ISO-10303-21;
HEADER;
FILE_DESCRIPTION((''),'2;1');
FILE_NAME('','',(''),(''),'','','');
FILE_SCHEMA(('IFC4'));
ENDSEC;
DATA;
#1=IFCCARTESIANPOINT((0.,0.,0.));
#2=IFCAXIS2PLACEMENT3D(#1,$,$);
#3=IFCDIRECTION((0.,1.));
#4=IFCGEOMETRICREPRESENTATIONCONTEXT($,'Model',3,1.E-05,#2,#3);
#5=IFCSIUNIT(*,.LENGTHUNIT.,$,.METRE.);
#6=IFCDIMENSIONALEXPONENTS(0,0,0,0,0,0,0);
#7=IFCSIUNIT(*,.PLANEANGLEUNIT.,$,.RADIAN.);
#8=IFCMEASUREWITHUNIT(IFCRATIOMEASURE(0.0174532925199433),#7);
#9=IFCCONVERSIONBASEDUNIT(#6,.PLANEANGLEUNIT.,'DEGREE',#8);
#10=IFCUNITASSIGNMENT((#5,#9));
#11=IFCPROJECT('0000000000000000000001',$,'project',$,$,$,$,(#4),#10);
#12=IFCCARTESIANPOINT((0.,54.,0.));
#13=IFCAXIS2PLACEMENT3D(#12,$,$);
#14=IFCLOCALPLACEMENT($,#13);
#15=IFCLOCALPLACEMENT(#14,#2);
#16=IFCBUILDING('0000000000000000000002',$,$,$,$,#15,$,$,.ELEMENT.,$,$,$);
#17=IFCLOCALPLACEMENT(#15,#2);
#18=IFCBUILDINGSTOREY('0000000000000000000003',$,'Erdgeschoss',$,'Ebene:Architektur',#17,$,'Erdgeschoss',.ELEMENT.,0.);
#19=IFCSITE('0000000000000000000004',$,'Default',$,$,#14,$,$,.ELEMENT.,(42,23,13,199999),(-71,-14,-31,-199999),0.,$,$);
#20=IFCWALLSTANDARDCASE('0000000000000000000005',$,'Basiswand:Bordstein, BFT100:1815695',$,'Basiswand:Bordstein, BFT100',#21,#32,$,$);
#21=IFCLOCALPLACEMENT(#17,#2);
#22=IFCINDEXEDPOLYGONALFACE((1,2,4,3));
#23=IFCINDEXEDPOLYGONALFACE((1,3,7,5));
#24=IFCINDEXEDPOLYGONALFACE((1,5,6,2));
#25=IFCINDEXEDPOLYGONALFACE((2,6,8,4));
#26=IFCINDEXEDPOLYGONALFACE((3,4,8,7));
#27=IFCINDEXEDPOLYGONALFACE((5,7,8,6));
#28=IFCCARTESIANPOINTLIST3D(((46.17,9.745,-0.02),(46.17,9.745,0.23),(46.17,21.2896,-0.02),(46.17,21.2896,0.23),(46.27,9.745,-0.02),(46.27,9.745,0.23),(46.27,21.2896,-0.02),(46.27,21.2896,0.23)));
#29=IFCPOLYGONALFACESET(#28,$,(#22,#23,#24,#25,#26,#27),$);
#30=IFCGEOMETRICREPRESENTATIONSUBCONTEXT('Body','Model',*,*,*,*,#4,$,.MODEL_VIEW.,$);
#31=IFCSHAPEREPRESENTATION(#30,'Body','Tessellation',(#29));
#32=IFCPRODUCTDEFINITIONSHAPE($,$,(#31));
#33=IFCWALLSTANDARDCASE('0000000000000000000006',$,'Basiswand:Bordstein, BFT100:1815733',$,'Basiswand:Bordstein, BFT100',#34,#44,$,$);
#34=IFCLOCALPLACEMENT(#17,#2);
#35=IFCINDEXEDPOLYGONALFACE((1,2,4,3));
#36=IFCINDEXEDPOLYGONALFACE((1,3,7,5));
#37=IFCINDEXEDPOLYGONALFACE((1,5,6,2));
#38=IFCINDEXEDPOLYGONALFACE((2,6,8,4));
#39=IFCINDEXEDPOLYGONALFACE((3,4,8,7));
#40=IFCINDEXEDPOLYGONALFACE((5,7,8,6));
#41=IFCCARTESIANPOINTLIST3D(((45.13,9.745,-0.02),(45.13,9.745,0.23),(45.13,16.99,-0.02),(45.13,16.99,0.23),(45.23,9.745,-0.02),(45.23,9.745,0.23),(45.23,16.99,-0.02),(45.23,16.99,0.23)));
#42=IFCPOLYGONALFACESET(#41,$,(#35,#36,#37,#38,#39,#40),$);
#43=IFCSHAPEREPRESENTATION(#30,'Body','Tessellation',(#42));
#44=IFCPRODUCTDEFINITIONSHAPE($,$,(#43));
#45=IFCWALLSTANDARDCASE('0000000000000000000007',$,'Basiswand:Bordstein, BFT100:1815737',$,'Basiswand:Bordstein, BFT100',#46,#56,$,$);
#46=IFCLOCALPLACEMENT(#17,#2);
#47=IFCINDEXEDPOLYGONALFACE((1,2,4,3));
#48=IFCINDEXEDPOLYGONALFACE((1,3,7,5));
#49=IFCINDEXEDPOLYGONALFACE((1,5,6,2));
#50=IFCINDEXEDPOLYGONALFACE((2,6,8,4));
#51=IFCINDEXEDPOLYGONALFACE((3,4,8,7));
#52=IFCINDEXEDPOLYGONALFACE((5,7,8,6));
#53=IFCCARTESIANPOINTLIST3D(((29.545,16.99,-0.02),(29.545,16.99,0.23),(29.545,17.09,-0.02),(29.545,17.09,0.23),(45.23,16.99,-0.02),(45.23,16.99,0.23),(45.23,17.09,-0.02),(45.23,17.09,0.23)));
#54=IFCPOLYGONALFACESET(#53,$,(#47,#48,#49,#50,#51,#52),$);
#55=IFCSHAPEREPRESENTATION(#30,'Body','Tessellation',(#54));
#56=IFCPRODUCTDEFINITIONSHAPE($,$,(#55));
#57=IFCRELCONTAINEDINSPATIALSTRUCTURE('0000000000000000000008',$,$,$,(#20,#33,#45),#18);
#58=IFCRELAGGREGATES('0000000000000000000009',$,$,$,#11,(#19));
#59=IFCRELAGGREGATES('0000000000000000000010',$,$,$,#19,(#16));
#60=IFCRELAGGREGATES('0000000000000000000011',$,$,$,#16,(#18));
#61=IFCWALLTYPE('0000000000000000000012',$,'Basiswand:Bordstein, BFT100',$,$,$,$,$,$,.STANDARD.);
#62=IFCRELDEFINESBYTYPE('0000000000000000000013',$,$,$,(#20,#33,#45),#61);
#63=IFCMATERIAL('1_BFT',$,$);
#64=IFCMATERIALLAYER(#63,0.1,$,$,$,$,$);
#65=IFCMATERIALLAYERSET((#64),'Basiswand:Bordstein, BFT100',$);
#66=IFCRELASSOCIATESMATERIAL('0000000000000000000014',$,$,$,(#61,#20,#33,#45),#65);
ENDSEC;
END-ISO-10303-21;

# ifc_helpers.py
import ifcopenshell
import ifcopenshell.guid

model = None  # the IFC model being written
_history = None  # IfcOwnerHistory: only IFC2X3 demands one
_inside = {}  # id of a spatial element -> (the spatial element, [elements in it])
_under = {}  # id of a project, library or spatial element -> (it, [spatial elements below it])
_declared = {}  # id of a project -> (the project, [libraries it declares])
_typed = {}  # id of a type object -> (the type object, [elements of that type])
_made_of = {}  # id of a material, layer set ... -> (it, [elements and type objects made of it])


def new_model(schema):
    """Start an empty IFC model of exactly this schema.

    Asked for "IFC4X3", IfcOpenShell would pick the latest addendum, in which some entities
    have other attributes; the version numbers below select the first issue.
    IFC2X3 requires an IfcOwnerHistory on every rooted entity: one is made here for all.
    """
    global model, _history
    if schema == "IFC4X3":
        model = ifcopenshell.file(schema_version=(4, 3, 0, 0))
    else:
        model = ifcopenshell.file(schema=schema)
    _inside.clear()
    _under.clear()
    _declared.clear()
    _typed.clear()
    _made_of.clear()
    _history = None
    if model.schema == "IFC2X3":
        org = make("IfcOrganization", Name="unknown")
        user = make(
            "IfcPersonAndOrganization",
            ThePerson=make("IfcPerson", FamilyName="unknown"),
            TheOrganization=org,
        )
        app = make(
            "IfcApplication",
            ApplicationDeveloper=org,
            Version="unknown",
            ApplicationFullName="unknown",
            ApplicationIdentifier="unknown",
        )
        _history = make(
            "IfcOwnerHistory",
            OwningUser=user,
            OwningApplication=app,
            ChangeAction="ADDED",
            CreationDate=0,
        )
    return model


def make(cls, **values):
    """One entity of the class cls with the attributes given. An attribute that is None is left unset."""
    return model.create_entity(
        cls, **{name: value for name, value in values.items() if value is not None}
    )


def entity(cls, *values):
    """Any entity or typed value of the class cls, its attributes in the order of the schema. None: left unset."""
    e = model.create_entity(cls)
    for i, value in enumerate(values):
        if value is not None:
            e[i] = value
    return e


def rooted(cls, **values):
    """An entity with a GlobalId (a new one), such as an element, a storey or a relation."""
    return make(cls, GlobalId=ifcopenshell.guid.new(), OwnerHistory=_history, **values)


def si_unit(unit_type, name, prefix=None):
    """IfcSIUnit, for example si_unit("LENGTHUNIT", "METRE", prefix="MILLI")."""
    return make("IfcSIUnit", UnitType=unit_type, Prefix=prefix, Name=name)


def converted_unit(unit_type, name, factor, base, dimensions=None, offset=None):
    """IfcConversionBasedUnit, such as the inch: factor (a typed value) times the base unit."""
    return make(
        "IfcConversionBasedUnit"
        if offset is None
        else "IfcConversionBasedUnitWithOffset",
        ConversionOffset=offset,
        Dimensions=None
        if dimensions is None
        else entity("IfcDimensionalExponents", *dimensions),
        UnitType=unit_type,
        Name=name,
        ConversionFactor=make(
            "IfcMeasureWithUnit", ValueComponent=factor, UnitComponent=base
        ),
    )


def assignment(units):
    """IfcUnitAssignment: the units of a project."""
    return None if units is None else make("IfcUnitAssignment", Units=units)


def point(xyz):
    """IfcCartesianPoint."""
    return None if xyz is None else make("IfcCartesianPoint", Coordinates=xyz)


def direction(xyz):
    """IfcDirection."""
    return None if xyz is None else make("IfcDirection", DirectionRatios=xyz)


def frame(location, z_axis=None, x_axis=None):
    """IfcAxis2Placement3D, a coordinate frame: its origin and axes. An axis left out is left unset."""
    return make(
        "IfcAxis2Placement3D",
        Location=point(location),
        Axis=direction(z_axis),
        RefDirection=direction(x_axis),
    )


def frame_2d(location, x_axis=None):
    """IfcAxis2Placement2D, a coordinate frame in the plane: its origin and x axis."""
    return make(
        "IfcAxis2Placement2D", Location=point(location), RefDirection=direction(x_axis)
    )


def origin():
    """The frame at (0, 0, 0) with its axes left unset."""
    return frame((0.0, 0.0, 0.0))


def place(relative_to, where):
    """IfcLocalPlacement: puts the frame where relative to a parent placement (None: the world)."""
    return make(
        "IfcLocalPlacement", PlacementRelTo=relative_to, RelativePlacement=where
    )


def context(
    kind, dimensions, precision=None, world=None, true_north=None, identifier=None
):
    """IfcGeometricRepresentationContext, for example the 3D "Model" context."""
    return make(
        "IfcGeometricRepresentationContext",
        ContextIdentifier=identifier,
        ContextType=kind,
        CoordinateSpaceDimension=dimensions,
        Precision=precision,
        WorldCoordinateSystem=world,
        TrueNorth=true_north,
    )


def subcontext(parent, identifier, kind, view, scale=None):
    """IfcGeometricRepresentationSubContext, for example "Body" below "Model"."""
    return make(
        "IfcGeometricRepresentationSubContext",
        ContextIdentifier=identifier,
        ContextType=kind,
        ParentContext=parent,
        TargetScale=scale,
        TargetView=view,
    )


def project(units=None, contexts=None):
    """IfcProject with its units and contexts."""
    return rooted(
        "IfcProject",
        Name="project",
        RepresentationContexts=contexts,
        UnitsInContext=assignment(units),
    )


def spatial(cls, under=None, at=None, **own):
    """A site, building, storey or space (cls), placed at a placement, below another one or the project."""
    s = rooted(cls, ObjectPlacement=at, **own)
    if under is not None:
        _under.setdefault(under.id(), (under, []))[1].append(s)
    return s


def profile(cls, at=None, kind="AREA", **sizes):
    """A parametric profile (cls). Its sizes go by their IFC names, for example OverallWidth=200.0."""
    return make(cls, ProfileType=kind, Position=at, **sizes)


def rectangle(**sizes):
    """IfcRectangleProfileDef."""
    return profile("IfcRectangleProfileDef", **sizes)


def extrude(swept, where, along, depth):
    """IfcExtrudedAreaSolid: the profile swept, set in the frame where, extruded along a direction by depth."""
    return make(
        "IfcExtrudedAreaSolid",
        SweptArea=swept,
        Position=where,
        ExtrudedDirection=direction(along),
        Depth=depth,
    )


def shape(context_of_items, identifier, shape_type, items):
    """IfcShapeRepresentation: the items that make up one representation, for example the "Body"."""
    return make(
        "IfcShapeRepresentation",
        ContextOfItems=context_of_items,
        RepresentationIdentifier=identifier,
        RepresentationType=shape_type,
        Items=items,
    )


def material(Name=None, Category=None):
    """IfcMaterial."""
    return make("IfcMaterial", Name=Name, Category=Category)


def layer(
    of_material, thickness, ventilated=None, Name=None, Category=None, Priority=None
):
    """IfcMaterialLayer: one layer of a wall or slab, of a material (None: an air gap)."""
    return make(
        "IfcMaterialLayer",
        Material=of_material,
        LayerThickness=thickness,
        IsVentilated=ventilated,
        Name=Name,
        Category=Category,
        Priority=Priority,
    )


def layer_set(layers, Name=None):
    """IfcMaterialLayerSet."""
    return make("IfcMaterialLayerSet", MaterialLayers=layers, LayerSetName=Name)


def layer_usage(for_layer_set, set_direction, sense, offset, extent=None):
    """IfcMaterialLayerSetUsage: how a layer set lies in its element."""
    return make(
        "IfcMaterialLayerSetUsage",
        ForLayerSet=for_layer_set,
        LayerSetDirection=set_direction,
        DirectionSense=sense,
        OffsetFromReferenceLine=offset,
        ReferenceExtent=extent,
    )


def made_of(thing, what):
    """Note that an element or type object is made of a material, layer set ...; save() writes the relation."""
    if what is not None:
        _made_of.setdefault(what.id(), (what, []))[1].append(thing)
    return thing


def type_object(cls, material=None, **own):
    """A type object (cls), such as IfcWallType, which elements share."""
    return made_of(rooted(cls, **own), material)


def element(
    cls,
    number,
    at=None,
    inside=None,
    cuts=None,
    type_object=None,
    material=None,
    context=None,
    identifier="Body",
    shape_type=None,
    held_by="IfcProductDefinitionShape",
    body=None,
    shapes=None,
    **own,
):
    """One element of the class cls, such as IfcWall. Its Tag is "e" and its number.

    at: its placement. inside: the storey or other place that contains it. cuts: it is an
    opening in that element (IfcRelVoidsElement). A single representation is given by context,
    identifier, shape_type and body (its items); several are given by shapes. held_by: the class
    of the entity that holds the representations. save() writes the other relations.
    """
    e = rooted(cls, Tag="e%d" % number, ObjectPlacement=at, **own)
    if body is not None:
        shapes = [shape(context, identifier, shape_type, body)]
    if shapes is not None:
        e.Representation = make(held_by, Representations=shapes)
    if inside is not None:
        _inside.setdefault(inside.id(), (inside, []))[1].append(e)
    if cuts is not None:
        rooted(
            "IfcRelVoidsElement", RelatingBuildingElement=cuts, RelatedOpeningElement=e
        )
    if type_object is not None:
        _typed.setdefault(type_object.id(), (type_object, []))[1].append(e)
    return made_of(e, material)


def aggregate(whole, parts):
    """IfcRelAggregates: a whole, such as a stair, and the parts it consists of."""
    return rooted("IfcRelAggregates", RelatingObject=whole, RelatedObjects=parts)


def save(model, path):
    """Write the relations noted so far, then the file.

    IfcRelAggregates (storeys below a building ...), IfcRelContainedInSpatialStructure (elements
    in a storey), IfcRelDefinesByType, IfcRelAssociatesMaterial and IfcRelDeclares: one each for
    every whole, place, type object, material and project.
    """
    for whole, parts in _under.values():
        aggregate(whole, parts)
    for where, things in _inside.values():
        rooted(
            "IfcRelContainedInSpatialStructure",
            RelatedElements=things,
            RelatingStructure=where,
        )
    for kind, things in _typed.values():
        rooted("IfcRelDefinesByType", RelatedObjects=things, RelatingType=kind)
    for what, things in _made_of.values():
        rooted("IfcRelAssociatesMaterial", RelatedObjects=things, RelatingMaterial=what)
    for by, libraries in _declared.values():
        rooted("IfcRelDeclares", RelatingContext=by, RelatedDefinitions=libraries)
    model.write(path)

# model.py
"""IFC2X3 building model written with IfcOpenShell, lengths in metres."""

from ifc_helpers import new_model, entity, si_unit, converted_unit, direction, frame, frame_2d, origin, place, context, subcontext, project, spatial, rectangle, extrude, material, layer, layer_set, layer_usage, type_object, element, save


model = new_model("IFC2X3")

# Units and contexts
model_context = context("Model", 3, precision=1e-05, world=origin(), true_north=direction((0.0, 1.0)))
body_context = subcontext(model_context, "Body", "Model", "MODEL_VIEW")
ifc_project = project(units=[si_unit("LENGTHUNIT", "METRE"), converted_unit("PLANEANGLEUNIT", "DEGREE", entity("IfcRatioMeasure", 0.0174532925199433), si_unit("PLANEANGLEUNIT", "RADIAN"), dimensions=[0, 0, 0, 0, 0, 0, 0])], contexts=[model_context])

# Site, building, storey
site_placement = place(None, frame((0.0, 54.0, 0.0)))
site = spatial("IfcSite", under=ifc_project, at=site_placement, Name="Default", CompositionType="ELEMENT", RefLatitude=(42, 23, 13, 199999), RefLongitude=(-71, -14, -31, -199999), RefElevation=0.0)
building_placement = place(site_placement, origin())
building = spatial("IfcBuilding", under=site, at=building_placement, CompositionType="ELEMENT")
storey_placement = place(building_placement, origin())
storey = spatial("IfcBuildingStorey", under=building, at=storey_placement, Name="Erdgeschoss", ObjectType="Ebene:Architektur", LongName="Erdgeschoss", CompositionType="ELEMENT", Elevation=0.0)

# Shared definitions
ifc_material_1 = material(Name="1_BFT")

# Walls
ifc_layer_1 = layer(ifc_material_1, 0.1)
ifc_layer_set_1 = layer_set([ifc_layer_1], Name="Basiswand:Bordstein, BFT100")
ifc_layer_usage_1 = layer_usage(ifc_layer_set_1, "AXIS2", "NEGATIVE", 0.05)
wall_type_1 = type_object("IfcWallType", Name="Basiswand:Bordstein, BFT100", PredefinedType="STANDARD", material=ifc_layer_set_1)
wall_1_placement = place(storey_placement, frame((46.22, 9.745, -0.02), z_axis=(0.0, 0.0, 1.0), x_axis=(0.0, 1.0, 0.0)))
element("IfcWallStandardCase", 1, at=wall_1_placement, inside=storey, type_object=wall_type_1, material=ifc_layer_usage_1, Name="Basiswand:Bordstein, BFT100:1815695", ObjectType="Basiswand:Bordstein, BFT100", context=body_context, shape_type="SweptSolid", body=[
    extrude(rectangle(XDim=11.5446, YDim=0.1, at=frame_2d((5.7723, 0.0), x_axis=(-1.0, 0.0))), origin(), (0.0, 0.0, 1.0), 0.25),
])
ifc_layer_usage_2 = layer_usage(ifc_layer_set_1, "AXIS2", "NEGATIVE", 0.05)
wall_2_placement = place(storey_placement, frame((45.18, 16.99, -0.02), z_axis=(0.0, 0.0, 1.0), x_axis=(0.0, -1.0, 0.0)))
element("IfcWallStandardCase", 2, at=wall_2_placement, inside=storey, type_object=wall_type_1, material=ifc_layer_usage_2, Name="Basiswand:Bordstein, BFT100:1815733", ObjectType="Basiswand:Bordstein, BFT100", context=body_context, shape_type="SweptSolid", body=[
    extrude(rectangle(XDim=7.245, YDim=0.1, at=frame_2d((3.6225, 0.0), x_axis=(-1.0, 0.0))), origin(), (0.0, 0.0, 1.0), 0.25),
])
ifc_layer_usage_3 = layer_usage(ifc_layer_set_1, "AXIS2", "NEGATIVE", 0.05)
wall_3_placement = place(storey_placement, frame((29.545, 17.04, -0.02)))
element("IfcWallStandardCase", 3, at=wall_3_placement, inside=storey, type_object=wall_type_1, material=ifc_layer_usage_3, Name="Basiswand:Bordstein, BFT100:1815737", ObjectType="Basiswand:Bordstein, BFT100", context=body_context, shape_type="SweptSolid", body=[
    extrude(rectangle(XDim=15.685, YDim=0.1, at=frame_2d((7.8425, 0.0), x_axis=(-1.0, 0.0))), origin(), (0.0, 0.0, 1.0), 0.25),
])

save(model, "model.ifc")
